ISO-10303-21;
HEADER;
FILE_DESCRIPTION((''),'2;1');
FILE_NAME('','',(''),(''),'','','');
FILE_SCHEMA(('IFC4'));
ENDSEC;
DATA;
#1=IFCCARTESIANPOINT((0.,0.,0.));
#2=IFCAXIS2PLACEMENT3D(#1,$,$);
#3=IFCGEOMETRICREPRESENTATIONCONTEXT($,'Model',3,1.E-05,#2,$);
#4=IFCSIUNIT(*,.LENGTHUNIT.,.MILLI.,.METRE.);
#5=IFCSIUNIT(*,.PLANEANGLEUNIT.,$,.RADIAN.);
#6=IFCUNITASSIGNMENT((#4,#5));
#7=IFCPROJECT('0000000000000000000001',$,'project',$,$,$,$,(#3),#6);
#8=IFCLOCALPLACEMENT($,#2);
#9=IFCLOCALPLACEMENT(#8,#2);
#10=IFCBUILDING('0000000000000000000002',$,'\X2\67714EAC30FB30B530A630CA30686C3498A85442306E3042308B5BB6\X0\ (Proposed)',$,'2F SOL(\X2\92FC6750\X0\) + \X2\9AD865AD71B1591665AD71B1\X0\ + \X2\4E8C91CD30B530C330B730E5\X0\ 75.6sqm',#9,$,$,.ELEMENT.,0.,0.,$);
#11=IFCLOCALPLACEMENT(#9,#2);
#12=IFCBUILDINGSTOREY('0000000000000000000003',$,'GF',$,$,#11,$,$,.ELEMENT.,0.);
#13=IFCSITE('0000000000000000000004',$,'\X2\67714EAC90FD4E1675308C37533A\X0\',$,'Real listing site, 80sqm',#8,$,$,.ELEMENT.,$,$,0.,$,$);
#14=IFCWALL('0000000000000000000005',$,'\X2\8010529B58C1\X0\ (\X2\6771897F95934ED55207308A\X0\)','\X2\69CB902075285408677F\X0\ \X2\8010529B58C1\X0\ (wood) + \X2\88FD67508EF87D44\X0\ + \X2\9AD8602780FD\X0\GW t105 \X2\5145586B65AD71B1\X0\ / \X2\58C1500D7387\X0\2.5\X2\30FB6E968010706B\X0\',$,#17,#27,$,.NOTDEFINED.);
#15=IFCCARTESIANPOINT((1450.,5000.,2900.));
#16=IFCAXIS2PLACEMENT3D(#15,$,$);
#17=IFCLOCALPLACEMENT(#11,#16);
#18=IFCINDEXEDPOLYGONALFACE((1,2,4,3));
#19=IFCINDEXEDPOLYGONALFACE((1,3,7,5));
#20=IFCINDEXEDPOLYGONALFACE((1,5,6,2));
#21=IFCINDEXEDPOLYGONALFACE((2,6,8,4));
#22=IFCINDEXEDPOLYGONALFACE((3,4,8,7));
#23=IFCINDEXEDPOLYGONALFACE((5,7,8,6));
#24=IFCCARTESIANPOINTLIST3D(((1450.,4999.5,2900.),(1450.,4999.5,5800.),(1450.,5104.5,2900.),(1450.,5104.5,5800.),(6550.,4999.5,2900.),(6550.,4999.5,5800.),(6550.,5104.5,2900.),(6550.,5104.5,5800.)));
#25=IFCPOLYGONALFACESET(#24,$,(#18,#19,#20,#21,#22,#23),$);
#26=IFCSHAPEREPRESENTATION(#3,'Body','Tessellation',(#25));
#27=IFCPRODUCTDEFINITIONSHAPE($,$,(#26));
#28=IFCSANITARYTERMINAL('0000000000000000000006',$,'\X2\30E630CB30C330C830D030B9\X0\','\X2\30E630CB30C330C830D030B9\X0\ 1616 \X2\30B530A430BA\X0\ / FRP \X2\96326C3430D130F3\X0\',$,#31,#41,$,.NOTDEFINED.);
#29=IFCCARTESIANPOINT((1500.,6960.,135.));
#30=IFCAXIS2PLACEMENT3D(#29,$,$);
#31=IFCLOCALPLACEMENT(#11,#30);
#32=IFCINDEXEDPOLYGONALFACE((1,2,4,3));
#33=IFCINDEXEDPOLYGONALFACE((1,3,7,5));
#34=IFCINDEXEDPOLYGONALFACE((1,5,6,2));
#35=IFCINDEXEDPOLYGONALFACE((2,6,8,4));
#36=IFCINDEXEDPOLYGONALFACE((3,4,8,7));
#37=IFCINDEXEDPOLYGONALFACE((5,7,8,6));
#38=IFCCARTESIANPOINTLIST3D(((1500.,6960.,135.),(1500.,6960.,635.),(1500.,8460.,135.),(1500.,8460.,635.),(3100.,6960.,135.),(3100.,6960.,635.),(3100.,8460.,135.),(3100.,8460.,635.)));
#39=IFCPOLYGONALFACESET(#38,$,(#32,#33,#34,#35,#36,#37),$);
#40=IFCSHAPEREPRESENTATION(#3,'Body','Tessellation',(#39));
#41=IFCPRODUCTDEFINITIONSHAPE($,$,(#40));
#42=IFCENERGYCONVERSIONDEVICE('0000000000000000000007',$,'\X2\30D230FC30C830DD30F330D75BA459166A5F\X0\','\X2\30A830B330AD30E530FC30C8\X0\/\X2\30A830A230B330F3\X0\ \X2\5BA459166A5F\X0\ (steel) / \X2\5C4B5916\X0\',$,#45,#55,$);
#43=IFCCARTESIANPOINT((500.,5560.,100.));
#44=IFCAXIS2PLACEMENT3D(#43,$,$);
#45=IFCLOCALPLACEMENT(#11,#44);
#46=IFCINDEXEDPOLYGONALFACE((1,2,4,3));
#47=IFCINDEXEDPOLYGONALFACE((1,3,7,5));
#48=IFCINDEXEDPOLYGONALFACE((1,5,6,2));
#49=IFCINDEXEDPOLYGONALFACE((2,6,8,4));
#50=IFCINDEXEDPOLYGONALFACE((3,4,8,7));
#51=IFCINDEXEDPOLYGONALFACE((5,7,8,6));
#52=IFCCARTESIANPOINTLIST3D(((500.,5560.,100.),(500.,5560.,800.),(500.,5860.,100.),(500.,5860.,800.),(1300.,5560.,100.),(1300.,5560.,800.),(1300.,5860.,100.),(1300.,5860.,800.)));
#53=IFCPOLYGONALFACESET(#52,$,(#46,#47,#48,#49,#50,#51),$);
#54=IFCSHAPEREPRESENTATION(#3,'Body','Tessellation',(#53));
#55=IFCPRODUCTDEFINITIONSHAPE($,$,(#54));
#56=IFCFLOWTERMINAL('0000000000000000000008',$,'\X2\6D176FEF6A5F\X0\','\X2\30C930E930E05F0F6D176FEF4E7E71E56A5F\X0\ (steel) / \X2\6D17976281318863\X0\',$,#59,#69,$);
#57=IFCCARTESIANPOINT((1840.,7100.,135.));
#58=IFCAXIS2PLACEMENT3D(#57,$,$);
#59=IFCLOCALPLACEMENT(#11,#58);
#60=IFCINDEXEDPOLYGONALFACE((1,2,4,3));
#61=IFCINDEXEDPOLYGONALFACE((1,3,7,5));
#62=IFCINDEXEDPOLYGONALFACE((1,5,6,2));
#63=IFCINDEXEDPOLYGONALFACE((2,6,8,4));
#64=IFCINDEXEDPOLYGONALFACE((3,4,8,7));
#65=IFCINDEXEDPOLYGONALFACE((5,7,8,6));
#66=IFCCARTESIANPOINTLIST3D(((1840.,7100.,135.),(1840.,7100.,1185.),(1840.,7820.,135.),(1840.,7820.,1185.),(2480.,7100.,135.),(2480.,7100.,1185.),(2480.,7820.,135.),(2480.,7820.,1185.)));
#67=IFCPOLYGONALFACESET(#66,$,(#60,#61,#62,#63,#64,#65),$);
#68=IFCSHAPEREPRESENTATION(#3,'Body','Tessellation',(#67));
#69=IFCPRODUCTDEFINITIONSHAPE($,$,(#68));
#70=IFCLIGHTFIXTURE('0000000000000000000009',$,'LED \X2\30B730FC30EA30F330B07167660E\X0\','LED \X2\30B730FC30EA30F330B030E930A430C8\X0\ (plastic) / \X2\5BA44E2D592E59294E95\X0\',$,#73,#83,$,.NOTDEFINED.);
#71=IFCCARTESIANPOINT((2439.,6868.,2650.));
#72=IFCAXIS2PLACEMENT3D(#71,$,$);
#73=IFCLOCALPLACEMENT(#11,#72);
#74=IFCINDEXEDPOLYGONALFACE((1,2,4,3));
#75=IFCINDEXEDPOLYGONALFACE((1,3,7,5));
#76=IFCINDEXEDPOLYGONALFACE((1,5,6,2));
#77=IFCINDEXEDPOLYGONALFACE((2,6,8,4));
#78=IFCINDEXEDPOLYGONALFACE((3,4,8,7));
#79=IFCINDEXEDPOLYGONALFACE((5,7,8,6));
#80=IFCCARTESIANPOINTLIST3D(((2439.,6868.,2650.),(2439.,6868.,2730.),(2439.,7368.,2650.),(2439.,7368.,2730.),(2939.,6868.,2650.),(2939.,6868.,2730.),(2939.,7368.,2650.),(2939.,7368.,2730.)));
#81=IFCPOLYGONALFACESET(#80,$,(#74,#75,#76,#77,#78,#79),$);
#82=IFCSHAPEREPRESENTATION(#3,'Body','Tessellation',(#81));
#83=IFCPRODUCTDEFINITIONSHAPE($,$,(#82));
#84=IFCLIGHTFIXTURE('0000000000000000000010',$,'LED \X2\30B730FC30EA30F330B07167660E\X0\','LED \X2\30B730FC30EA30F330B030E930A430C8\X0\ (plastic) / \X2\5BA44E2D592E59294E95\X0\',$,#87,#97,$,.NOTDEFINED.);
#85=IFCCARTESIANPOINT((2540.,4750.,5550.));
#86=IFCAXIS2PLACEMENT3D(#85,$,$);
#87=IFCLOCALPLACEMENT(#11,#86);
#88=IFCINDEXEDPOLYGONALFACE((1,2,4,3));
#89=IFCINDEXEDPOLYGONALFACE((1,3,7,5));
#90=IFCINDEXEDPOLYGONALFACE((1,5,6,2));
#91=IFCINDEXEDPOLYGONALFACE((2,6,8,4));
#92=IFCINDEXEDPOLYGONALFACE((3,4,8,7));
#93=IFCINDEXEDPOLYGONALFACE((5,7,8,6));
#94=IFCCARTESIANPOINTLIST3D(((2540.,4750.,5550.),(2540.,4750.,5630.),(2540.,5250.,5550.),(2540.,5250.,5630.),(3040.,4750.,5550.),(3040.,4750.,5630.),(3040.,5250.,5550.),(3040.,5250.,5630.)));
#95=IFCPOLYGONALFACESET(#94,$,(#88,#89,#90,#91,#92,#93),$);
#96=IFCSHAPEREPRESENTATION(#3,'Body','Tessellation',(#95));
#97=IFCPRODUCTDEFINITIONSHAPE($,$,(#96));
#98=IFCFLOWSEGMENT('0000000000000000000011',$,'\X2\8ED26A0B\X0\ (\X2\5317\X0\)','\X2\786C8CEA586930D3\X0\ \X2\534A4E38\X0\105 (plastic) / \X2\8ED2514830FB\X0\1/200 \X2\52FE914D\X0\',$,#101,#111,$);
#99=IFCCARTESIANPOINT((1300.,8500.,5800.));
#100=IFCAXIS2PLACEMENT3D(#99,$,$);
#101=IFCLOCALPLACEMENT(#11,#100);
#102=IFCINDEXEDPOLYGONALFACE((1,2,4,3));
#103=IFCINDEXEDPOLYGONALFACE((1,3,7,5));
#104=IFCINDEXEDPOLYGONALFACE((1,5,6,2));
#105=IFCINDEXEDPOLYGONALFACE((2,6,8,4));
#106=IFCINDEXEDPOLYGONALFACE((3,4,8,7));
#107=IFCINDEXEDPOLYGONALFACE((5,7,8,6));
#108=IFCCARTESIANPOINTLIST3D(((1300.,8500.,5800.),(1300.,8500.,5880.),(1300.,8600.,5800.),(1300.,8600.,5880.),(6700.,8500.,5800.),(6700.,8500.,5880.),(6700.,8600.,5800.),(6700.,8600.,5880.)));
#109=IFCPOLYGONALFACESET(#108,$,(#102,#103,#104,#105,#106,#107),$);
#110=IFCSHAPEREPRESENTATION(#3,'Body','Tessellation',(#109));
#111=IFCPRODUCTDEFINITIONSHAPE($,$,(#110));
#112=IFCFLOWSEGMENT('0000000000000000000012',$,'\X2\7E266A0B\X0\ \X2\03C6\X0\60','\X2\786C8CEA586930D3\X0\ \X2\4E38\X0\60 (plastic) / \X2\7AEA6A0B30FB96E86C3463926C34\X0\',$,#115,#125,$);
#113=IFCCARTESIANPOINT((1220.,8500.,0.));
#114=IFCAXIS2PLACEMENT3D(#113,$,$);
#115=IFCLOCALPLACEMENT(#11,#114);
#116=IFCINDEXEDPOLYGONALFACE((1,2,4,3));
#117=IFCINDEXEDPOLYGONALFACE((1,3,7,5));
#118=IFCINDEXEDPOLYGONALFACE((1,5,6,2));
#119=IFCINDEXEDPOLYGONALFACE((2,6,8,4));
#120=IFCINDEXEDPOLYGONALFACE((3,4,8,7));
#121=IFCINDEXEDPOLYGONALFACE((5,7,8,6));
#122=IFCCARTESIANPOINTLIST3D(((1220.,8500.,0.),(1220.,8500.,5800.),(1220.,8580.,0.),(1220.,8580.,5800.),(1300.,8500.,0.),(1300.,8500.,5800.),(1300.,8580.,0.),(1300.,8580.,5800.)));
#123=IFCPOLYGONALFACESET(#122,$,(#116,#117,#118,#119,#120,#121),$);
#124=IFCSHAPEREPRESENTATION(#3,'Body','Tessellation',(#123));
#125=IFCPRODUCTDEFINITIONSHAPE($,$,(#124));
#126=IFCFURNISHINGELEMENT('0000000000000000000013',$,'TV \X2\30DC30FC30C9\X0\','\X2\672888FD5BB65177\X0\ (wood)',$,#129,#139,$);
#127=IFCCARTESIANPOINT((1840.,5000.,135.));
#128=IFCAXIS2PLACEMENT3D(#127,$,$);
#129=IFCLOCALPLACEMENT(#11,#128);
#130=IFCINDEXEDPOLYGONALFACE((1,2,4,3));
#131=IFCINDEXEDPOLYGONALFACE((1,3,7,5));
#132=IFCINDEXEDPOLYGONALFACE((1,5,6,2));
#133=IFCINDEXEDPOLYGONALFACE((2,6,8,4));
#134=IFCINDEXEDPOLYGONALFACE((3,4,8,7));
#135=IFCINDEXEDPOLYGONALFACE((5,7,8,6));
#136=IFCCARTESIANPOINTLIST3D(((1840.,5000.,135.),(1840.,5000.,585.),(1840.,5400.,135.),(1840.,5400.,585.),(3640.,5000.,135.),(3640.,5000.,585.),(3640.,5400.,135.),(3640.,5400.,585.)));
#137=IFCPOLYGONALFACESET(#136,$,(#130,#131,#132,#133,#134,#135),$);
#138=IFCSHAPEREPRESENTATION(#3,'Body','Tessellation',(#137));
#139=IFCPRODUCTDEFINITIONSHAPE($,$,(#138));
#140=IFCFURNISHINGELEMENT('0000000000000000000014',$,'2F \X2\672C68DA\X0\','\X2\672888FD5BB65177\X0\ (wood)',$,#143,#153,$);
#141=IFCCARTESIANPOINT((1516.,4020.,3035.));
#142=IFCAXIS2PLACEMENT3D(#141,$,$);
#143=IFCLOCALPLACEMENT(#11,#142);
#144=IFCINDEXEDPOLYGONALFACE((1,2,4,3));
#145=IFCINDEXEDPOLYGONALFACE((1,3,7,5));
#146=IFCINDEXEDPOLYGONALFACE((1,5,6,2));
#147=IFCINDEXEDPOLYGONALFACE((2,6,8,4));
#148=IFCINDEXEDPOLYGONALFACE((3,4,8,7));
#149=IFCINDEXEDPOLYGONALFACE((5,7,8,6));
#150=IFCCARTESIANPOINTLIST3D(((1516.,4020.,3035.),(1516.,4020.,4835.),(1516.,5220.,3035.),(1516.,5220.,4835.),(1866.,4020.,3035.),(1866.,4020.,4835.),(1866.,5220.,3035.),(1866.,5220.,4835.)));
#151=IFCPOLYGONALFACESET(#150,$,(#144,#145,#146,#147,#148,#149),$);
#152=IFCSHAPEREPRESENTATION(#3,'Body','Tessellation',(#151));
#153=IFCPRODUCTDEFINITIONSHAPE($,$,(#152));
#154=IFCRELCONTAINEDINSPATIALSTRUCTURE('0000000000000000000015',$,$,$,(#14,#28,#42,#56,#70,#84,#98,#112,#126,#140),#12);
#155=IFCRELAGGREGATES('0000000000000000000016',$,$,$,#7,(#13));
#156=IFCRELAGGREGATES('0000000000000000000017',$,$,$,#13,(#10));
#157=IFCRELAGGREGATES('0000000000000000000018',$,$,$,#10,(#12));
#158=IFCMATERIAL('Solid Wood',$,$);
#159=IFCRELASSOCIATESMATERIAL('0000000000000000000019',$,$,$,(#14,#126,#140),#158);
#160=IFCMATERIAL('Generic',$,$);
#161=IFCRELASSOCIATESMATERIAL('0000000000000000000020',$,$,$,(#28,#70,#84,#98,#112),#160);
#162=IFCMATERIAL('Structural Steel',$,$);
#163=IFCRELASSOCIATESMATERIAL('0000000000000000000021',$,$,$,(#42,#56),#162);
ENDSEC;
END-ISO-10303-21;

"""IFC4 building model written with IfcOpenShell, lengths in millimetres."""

from ifc_helpers import new_model, si_unit, frame, frame_2d, origin, place, context, project, spatial, rectangle, extrude, material, element, save


model = new_model("IFC4")

# Units and contexts
model_context = context("Model", 3, precision=1e-05, world=origin())
ifc_project = project(units=[si_unit("LENGTHUNIT", "METRE", prefix="MILLI"), si_unit("PLANEANGLEUNIT", "RADIAN")], contexts=[model_context])

# Site, building, storey
site_placement = place(None, origin())
site = spatial("IfcSite", under=ifc_project, at=site_placement, Name="東京都世田谷区", ObjectType="Real listing site, 80sqm", CompositionType="ELEMENT", RefElevation=0.0)
building_placement = place(site_placement, origin())
building = spatial("IfcBuilding", under=site, at=building_placement, Name="東京・サウナと水風呂のある家 (Proposed)", ObjectType="2F SOL(鋼材) + 高断熱外断熱 + 二重サッシュ 75.6sqm", CompositionType="ELEMENT", ElevationOfRefHeight=0.0, ElevationOfTerrain=0.0)
storey_placement = place(building_placement, origin())
storey = spatial("IfcBuildingStorey", under=building, at=storey_placement, Name="GF", CompositionType="ELEMENT", Elevation=0.0)

# Shared definitions
ifc_material_1 = material(Name="Solid Wood")

# Wall
wall_1_placement = place(storey_placement, frame((1450.0, 5000.0, 2900.0)))
element("IfcWall", 1, at=wall_1_placement, inside=storey, material=ifc_material_1, Name="耐力壁 (東西間仕切り)", Description="構造用合板 耐力壁 (wood) + 製材軸組 + 高性能GW t105 充填断熱 / 壁倍率2.5・準耐火", PredefinedType="NOTDEFINED", context=model_context, shape_type="SweptSolid", body=[
    extrude(rectangle(XDim=5100.0, YDim=105.0, at=frame_2d((2550.0, 52.0))), frame((1450.0, 5000.0, 2900.0)), (0.0, 0.0, 1.0), 2900.0),
])

# Sanitary terminal
ifc_material_2 = material(Name="Generic")
sanitary_terminal_placement = place(storey_placement, frame((1500.0, 6960.0, 135.0)))
element("IfcSanitaryTerminal", 2, at=sanitary_terminal_placement, inside=storey, material=ifc_material_2, Name="ユニットバス", Description="ユニットバス 1616 サイズ / FRP 防水パン", PredefinedType="NOTDEFINED", context=model_context, shape_type="SweptSolid", body=[
    extrude(rectangle(XDim=1600.0, YDim=1500.0, at=frame_2d((800.0, 750.0))), frame((1500.0, 6960.0, 135.0)), (0.0, 0.0, 1.0), 500.0),
])

# Shared definitions
ifc_material_3 = material(Name="Structural Steel")

# Energy conversion device
energy_conversion_device_placement = place(storey_placement, frame((500.0, 5560.0, 100.0)))
element("IfcEnergyConversionDevice", 3, at=energy_conversion_device_placement, inside=storey, material=ifc_material_3, Name="ヒートポンプ室外機", Description="エコキュート/エアコン 室外機 (steel) / 屋外", context=model_context, shape_type="SweptSolid", body=[
    extrude(rectangle(XDim=800.0, YDim=300.0, at=frame_2d((400.0, 150.0))), frame((500.0, 5560.0, 100.0)), (0.0, 0.0, 1.0), 700.0),
])

# Flow terminal
flow_terminal_placement = place(storey_placement, frame((1840.0, 7100.0, 135.0)))
element("IfcFlowTerminal", 4, at=flow_terminal_placement, inside=storey, material=ifc_material_3, Name="洗濯機", Description="ドラム式洗濯乾燥機 (steel) / 洗面脱衣", context=model_context, shape_type="SweptSolid", body=[
    extrude(rectangle(XDim=640.0, YDim=720.0, at=frame_2d((320.0, 360.0))), frame((1840.0, 7100.0, 135.0)), (0.0, 0.0, 1.0), 1050.0),
])

# Light fixtures
light_fixture_1_placement = place(storey_placement, frame((2439.0, 6868.0, 2650.0)))
element("IfcLightFixture", 5, at=light_fixture_1_placement, inside=storey, material=ifc_material_2, Name="LED シーリング照明", Description="LED シーリングライト (plastic) / 室中央天井", PredefinedType="NOTDEFINED", context=model_context, shape_type="SweptSolid", body=[
    extrude(rectangle(XDim=500.0, YDim=500.0, at=frame_2d((250.0, 250.0))), frame((2439.0, 6868.0, 2650.0)), (0.0, 0.0, 1.0), 80.0),
])
light_fixture_2_placement = place(storey_placement, frame((2540.0, 4750.0, 5550.0)))
element("IfcLightFixture", 6, at=light_fixture_2_placement, inside=storey, material=ifc_material_2, Name="LED シーリング照明", Description="LED シーリングライト (plastic) / 室中央天井", PredefinedType="NOTDEFINED", context=model_context, shape_type="SweptSolid", body=[
    extrude(rectangle(XDim=500.0, YDim=500.0, at=frame_2d((250.0, 250.0))), frame((2540.0, 4750.0, 5550.0)), (0.0, 0.0, 1.0), 80.0),
])

# Flow segments
flow_segment_1_placement = place(storey_placement, frame((1300.0, 8500.0, 5800.0)))
element("IfcFlowSegment", 7, at=flow_segment_1_placement, inside=storey, material=ifc_material_2, Name="軒樋 (北)", Description="硬質塩ビ 半丸105 (plastic) / 軒先・1/200 勾配", context=model_context, shape_type="SweptSolid", body=[
    extrude(rectangle(XDim=5400.0, YDim=100.0, at=frame_2d((2700.0, 50.0))), frame((1300.0, 8500.0, 5800.0)), (0.0, 0.0, 1.0), 80.0),
])
flow_segment_2_placement = place(storey_placement, frame((1220.0, 8500.0, 0.0)))
element("IfcFlowSegment", 8, at=flow_segment_2_placement, inside=storey, material=ifc_material_2, Name="縦樋 φ60", Description="硬質塩ビ 丸60 (plastic) / 竪樋・雨水排水", context=model_context, shape_type="SweptSolid", body=[
    extrude(rectangle(XDim=80.0, YDim=80.0, at=frame_2d((40.0, 40.0))), frame((1220.0, 8500.0, 0.0)), (0.0, 0.0, 1.0), 5800.0),
])

# Furnishing elements
furnishing_1_placement = place(storey_placement, frame((1840.0, 5000.0, 135.0)))
element("IfcFurnishingElement", 9, at=furnishing_1_placement, inside=storey, material=ifc_material_1, Name="TV ボード", Description="木製家具 (wood)", context=model_context, shape_type="SweptSolid", body=[
    extrude(rectangle(XDim=1800.0, YDim=400.0, at=frame_2d((900.0, 200.0))), frame((1840.0, 5000.0, 135.0)), (0.0, 0.0, 1.0), 450.0),
])
furnishing_2_placement = place(storey_placement, frame((1516.0, 4020.0, 3035.0)))
element("IfcFurnishingElement", 10, at=furnishing_2_placement, inside=storey, material=ifc_material_1, Name="2F 本棚", Description="木製家具 (wood)", context=model_context, shape_type="SweptSolid", body=[
    extrude(rectangle(XDim=350.0, YDim=1200.0, at=frame_2d((175.0, 600.0))), frame((1516.0, 4020.0, 3035.0)), (0.0, 0.0, 1.0), 1800.0),
])

save(model, "model.ifc")
